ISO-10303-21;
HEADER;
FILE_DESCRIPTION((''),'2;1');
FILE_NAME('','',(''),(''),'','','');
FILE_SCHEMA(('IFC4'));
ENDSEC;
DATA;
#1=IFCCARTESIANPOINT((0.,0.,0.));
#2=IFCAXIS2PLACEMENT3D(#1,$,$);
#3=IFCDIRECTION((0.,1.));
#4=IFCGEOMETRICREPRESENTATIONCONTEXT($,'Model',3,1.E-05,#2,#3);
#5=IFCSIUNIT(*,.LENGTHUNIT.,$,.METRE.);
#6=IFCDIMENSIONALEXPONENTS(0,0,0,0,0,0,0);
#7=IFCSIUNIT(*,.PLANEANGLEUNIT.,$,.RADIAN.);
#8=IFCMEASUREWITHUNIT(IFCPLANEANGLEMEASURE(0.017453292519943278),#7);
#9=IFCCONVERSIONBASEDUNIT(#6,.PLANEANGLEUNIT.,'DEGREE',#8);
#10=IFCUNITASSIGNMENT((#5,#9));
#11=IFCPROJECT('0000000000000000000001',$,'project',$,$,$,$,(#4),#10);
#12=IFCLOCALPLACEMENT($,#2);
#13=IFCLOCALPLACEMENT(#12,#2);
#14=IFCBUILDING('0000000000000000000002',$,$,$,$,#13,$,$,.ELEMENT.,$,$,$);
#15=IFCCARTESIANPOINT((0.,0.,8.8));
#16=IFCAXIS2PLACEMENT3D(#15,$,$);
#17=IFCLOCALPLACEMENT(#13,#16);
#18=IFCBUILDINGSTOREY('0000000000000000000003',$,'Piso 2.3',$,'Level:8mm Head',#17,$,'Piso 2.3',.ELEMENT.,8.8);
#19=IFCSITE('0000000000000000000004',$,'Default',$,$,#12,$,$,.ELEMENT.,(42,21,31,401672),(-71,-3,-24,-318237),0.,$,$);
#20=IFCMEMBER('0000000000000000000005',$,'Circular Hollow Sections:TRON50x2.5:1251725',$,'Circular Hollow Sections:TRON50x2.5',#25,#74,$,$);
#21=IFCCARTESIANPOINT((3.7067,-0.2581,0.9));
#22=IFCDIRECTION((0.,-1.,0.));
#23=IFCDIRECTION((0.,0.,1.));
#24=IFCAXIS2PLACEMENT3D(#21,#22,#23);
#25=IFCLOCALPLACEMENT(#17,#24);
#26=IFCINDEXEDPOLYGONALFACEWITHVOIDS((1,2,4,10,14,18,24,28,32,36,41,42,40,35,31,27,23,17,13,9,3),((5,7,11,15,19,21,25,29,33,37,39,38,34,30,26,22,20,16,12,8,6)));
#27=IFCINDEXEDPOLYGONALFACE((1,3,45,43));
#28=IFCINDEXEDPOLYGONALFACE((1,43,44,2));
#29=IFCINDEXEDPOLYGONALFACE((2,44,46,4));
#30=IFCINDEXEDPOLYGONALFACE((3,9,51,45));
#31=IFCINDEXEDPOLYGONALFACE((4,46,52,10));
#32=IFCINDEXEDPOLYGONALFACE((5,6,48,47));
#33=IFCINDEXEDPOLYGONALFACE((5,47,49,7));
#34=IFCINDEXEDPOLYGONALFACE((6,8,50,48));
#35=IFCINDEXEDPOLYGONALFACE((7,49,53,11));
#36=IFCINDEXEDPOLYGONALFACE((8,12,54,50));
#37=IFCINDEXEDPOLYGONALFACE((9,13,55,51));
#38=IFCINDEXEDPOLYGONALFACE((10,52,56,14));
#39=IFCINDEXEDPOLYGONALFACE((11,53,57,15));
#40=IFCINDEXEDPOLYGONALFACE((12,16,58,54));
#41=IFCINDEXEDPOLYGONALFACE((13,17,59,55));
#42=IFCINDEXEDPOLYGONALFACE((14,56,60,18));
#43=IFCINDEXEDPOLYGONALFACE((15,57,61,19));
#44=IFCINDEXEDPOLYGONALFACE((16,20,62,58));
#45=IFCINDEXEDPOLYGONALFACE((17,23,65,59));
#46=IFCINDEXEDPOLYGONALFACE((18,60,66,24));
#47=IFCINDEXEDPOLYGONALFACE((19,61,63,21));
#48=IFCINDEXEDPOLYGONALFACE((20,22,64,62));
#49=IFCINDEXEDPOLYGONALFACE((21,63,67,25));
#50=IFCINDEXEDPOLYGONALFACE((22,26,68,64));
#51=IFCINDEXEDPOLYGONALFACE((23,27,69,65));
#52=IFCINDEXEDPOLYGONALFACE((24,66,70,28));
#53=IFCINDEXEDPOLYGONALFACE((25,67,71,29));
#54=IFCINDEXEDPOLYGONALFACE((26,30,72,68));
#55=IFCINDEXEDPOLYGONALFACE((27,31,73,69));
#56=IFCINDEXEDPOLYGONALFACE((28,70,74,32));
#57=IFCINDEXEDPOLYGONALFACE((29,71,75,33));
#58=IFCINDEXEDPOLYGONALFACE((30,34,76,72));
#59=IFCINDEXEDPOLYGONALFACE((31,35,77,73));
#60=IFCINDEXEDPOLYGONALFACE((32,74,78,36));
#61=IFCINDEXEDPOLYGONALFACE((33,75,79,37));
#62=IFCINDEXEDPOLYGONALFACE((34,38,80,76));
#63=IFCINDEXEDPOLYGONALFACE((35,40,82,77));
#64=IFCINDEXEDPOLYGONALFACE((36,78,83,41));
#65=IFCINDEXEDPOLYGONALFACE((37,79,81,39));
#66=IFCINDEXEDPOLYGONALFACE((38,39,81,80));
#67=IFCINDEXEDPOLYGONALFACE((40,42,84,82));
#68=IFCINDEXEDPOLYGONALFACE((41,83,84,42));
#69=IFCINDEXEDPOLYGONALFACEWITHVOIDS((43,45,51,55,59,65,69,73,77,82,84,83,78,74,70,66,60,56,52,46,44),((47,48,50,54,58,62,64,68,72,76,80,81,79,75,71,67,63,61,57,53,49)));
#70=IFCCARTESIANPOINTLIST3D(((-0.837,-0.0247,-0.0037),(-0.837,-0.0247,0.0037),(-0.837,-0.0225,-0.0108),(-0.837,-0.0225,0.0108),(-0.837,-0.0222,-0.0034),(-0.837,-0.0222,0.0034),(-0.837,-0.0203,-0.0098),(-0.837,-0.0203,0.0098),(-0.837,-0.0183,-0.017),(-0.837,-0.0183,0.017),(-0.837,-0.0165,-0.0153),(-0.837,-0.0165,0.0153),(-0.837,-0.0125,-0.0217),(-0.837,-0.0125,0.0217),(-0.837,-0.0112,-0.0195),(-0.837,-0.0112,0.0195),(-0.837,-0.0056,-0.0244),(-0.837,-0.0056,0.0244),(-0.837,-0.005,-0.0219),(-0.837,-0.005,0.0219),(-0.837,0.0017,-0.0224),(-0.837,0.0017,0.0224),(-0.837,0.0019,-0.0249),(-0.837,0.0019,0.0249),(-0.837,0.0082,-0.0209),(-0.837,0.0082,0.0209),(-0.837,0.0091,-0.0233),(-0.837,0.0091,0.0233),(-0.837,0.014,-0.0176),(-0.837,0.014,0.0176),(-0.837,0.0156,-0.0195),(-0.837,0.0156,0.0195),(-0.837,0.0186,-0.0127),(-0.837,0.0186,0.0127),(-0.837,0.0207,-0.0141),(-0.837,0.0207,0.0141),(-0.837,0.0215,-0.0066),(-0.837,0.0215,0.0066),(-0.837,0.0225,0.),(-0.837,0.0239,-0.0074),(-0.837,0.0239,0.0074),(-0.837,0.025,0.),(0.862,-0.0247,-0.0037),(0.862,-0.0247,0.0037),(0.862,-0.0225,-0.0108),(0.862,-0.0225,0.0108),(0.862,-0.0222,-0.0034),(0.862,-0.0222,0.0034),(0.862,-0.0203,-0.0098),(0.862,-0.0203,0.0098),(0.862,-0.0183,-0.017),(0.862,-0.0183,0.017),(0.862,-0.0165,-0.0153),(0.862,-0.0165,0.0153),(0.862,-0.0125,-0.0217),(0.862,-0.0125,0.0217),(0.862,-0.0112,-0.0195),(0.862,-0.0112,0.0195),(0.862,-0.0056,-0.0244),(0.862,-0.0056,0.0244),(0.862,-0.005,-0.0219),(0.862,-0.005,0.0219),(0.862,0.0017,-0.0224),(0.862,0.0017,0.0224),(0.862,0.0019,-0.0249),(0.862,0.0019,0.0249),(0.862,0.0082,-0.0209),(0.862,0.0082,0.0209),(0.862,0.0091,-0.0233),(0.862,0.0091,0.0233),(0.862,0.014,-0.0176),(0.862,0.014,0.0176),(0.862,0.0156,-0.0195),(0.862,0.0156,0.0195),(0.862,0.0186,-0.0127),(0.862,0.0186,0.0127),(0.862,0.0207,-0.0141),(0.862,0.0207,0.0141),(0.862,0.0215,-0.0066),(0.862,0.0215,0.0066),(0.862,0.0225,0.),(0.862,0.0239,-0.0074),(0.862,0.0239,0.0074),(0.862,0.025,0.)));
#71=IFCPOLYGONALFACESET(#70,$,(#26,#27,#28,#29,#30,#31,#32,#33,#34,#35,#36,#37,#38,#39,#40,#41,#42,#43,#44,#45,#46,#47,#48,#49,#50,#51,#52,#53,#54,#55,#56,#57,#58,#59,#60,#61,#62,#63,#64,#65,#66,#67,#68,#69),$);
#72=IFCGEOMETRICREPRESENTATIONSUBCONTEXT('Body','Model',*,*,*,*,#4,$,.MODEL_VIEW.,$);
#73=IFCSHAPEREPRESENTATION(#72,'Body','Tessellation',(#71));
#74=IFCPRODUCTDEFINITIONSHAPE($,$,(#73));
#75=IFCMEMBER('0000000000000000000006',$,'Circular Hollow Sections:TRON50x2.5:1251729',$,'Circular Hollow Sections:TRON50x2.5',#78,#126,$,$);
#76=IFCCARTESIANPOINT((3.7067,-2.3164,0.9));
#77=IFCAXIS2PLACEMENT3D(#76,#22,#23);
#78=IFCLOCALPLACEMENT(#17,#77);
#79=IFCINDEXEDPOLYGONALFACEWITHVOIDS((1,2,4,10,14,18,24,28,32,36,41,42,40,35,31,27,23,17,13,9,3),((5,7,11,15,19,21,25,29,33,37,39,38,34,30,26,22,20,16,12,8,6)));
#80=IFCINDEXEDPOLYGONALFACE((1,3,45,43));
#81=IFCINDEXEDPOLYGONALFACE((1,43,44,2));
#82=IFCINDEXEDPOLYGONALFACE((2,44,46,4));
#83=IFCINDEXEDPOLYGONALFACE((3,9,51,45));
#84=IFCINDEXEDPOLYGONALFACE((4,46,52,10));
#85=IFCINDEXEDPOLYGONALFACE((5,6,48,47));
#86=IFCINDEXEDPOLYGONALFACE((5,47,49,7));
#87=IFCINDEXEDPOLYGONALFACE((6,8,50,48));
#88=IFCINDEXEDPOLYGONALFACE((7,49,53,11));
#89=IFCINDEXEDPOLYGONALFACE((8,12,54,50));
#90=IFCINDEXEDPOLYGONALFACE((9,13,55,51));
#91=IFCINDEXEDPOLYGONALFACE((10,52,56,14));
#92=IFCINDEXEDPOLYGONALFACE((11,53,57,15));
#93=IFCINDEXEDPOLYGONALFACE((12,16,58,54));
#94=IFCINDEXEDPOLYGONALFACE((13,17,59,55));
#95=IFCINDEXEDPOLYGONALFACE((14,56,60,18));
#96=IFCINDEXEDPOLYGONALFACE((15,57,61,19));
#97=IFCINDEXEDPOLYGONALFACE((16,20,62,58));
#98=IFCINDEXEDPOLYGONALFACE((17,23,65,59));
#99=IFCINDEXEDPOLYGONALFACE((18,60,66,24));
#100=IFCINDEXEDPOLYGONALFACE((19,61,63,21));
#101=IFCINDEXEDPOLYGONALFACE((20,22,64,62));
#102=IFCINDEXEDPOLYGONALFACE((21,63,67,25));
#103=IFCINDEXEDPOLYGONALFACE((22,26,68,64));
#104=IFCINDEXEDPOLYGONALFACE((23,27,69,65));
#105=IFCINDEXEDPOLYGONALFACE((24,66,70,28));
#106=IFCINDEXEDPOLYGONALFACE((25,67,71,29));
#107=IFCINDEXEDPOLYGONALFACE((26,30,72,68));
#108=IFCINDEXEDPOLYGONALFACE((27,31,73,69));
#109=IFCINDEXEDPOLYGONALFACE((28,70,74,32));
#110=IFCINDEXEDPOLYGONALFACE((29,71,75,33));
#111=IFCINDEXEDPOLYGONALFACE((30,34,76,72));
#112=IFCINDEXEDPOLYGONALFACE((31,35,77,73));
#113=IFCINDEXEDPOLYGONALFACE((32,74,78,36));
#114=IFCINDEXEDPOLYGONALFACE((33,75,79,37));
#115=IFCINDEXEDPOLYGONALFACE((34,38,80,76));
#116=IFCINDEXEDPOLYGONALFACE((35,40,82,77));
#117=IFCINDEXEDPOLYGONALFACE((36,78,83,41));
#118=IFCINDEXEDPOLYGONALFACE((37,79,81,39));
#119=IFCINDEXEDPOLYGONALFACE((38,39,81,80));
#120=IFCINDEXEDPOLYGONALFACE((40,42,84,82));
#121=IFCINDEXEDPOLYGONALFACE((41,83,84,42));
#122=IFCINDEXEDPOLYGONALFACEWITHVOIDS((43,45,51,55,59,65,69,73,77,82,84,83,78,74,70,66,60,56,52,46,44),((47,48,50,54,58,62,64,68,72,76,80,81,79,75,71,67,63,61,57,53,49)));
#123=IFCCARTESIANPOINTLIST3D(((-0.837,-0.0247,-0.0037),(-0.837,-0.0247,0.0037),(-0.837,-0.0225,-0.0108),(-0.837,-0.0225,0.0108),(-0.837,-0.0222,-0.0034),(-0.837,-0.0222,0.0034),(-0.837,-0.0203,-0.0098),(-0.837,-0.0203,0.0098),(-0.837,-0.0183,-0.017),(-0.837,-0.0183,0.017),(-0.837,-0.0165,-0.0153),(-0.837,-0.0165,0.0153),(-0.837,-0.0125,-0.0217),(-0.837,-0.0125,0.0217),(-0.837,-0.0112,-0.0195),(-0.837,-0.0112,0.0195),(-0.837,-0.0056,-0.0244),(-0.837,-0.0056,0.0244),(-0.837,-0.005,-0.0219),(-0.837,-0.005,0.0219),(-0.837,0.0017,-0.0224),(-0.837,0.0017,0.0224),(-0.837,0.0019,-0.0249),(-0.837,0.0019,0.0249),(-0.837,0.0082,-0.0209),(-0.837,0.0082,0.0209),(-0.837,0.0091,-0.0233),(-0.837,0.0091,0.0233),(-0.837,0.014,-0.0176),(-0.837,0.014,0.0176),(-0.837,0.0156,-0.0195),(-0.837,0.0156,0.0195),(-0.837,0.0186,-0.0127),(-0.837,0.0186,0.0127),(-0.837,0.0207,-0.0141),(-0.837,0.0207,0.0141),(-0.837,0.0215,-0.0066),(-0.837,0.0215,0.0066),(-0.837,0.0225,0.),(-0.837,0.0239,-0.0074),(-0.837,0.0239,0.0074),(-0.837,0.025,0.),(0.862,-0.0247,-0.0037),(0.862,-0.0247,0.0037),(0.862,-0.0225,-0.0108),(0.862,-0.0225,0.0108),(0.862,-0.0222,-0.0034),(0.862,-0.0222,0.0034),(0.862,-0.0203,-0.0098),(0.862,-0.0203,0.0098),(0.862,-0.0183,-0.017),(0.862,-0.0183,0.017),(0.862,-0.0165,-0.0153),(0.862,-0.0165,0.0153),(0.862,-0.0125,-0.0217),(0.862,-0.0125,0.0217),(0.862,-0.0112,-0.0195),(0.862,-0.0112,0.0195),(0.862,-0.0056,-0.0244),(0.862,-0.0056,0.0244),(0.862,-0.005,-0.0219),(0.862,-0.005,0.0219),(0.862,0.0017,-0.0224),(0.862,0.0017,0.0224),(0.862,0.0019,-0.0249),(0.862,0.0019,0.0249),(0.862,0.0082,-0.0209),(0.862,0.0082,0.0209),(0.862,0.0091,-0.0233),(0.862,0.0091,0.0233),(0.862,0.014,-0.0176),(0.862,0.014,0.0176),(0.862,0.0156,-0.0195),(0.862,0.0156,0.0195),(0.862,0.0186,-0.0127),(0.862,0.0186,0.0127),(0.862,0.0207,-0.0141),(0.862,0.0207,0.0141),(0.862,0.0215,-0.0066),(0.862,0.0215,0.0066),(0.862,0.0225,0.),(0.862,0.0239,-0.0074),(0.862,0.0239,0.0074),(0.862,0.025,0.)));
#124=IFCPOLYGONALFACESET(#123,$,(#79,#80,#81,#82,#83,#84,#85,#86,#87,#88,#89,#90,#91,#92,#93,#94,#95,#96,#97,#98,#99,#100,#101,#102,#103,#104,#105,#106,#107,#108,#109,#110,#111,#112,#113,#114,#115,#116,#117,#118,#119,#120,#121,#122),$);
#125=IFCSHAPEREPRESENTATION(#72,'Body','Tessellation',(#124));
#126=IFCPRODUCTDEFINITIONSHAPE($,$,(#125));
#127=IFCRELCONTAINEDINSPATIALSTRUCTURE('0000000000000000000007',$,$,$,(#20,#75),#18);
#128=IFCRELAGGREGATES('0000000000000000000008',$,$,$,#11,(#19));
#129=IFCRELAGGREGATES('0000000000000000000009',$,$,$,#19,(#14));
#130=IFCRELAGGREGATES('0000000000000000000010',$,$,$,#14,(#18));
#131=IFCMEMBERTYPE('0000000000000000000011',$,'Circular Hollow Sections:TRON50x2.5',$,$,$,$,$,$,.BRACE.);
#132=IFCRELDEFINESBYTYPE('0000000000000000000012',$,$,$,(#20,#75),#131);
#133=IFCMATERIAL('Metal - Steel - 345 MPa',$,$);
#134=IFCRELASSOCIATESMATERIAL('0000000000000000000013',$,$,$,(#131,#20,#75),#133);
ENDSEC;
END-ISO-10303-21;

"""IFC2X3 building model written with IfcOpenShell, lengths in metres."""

from ifc_helpers import new_model, entity, si_unit, converted_unit, direction, frame, frame_2d, origin, place, context, subcontext, project, spatial, hollow_circle, extrude, source, transform, mapped, material, type_object, type_shapes, element, save


model = new_model("IFC2X3")

# Units and contexts
model_context = context("Model", 3, precision=1e-05, world=origin(), true_north=direction((0.0, 1.0)))
body_context = subcontext(model_context, "Body", "Model", "MODEL_VIEW")
ifc_project = project(units=[si_unit("LENGTHUNIT", "METRE"), converted_unit("PLANEANGLEUNIT", "DEGREE", entity("IfcPlaneAngleMeasure", 0.017453292519943278), si_unit("PLANEANGLEUNIT", "RADIAN"), dimensions=[0, 0, 0, 0, 0, 0, 0])], contexts=[model_context])

# Site, building, storey
site_placement = place(None, origin())
site = spatial("IfcSite", under=ifc_project, at=site_placement, Name="Default", CompositionType="ELEMENT", RefLatitude=(42, 21, 31, 401672), RefLongitude=(-71, -3, -24, -318237), RefElevation=0.0)
building_placement = place(site_placement, origin())
building = spatial("IfcBuilding", under=site, at=building_placement, CompositionType="ELEMENT")
storey_placement = place(building_placement, frame((0.0, 0.0, 8.8)))
storey = spatial("IfcBuildingStorey", under=building, at=storey_placement, Name="Piso 2.3", ObjectType="Level:8mm Head", LongName="Piso 2.3", CompositionType="ELEMENT", Elevation=8.8)

# Shared definitions
ifc_material_1 = material(Name="Metal - Steel - 345 MPa")

# Members
member_type_1 = type_object("IfcMemberType", Name="Circular Hollow Sections:TRON50x2.5", PredefinedType="BRACE", material=ifc_material_1)
shared_shape_1 = source(origin(), body_context, "Body", "SweptSolid", [
    extrude(hollow_circle(Radius=0.025, WallThickness=0.0025, at=frame_2d((0.0, 0.0), x_axis=(1.0, 0.0))), frame((-0.837, 0.0, 0.0), z_axis=(1.0, 0.0, 0.0), x_axis=(0.0, 1.0, 0.0)), (0.0, 0.0, 1.0), 1.699),
])
type_shapes(member_type_1, [shared_shape_1])
for number, where, z_axis, x_axis, name in (
    (1, (3.7067, -0.2581, 0.9), (0.0, -1.0, 0.0), (0.0, 0.0, 1.0), "Circular Hollow Sections:TRON50x2.5:1251725"),
    (2, (3.7067, -2.3164, 0.9), (0.0, -1.0, 0.0), (0.0, 0.0, 1.0), "Circular Hollow Sections:TRON50x2.5:1251729"),
):
    element("IfcMember", number, at=place(storey_placement, frame(where, z_axis=z_axis, x_axis=x_axis)), inside=storey, type_object=member_type_1, material=ifc_material_1, Name=name, ObjectType="Circular Hollow Sections:TRON50x2.5", context=body_context, shape_type="MappedRepresentation", body=[
        mapped(shared_shape_1, transform((0.0, 0.0, 0.0), scale=1.0)),
    ])

save(model, "model.ifc")
